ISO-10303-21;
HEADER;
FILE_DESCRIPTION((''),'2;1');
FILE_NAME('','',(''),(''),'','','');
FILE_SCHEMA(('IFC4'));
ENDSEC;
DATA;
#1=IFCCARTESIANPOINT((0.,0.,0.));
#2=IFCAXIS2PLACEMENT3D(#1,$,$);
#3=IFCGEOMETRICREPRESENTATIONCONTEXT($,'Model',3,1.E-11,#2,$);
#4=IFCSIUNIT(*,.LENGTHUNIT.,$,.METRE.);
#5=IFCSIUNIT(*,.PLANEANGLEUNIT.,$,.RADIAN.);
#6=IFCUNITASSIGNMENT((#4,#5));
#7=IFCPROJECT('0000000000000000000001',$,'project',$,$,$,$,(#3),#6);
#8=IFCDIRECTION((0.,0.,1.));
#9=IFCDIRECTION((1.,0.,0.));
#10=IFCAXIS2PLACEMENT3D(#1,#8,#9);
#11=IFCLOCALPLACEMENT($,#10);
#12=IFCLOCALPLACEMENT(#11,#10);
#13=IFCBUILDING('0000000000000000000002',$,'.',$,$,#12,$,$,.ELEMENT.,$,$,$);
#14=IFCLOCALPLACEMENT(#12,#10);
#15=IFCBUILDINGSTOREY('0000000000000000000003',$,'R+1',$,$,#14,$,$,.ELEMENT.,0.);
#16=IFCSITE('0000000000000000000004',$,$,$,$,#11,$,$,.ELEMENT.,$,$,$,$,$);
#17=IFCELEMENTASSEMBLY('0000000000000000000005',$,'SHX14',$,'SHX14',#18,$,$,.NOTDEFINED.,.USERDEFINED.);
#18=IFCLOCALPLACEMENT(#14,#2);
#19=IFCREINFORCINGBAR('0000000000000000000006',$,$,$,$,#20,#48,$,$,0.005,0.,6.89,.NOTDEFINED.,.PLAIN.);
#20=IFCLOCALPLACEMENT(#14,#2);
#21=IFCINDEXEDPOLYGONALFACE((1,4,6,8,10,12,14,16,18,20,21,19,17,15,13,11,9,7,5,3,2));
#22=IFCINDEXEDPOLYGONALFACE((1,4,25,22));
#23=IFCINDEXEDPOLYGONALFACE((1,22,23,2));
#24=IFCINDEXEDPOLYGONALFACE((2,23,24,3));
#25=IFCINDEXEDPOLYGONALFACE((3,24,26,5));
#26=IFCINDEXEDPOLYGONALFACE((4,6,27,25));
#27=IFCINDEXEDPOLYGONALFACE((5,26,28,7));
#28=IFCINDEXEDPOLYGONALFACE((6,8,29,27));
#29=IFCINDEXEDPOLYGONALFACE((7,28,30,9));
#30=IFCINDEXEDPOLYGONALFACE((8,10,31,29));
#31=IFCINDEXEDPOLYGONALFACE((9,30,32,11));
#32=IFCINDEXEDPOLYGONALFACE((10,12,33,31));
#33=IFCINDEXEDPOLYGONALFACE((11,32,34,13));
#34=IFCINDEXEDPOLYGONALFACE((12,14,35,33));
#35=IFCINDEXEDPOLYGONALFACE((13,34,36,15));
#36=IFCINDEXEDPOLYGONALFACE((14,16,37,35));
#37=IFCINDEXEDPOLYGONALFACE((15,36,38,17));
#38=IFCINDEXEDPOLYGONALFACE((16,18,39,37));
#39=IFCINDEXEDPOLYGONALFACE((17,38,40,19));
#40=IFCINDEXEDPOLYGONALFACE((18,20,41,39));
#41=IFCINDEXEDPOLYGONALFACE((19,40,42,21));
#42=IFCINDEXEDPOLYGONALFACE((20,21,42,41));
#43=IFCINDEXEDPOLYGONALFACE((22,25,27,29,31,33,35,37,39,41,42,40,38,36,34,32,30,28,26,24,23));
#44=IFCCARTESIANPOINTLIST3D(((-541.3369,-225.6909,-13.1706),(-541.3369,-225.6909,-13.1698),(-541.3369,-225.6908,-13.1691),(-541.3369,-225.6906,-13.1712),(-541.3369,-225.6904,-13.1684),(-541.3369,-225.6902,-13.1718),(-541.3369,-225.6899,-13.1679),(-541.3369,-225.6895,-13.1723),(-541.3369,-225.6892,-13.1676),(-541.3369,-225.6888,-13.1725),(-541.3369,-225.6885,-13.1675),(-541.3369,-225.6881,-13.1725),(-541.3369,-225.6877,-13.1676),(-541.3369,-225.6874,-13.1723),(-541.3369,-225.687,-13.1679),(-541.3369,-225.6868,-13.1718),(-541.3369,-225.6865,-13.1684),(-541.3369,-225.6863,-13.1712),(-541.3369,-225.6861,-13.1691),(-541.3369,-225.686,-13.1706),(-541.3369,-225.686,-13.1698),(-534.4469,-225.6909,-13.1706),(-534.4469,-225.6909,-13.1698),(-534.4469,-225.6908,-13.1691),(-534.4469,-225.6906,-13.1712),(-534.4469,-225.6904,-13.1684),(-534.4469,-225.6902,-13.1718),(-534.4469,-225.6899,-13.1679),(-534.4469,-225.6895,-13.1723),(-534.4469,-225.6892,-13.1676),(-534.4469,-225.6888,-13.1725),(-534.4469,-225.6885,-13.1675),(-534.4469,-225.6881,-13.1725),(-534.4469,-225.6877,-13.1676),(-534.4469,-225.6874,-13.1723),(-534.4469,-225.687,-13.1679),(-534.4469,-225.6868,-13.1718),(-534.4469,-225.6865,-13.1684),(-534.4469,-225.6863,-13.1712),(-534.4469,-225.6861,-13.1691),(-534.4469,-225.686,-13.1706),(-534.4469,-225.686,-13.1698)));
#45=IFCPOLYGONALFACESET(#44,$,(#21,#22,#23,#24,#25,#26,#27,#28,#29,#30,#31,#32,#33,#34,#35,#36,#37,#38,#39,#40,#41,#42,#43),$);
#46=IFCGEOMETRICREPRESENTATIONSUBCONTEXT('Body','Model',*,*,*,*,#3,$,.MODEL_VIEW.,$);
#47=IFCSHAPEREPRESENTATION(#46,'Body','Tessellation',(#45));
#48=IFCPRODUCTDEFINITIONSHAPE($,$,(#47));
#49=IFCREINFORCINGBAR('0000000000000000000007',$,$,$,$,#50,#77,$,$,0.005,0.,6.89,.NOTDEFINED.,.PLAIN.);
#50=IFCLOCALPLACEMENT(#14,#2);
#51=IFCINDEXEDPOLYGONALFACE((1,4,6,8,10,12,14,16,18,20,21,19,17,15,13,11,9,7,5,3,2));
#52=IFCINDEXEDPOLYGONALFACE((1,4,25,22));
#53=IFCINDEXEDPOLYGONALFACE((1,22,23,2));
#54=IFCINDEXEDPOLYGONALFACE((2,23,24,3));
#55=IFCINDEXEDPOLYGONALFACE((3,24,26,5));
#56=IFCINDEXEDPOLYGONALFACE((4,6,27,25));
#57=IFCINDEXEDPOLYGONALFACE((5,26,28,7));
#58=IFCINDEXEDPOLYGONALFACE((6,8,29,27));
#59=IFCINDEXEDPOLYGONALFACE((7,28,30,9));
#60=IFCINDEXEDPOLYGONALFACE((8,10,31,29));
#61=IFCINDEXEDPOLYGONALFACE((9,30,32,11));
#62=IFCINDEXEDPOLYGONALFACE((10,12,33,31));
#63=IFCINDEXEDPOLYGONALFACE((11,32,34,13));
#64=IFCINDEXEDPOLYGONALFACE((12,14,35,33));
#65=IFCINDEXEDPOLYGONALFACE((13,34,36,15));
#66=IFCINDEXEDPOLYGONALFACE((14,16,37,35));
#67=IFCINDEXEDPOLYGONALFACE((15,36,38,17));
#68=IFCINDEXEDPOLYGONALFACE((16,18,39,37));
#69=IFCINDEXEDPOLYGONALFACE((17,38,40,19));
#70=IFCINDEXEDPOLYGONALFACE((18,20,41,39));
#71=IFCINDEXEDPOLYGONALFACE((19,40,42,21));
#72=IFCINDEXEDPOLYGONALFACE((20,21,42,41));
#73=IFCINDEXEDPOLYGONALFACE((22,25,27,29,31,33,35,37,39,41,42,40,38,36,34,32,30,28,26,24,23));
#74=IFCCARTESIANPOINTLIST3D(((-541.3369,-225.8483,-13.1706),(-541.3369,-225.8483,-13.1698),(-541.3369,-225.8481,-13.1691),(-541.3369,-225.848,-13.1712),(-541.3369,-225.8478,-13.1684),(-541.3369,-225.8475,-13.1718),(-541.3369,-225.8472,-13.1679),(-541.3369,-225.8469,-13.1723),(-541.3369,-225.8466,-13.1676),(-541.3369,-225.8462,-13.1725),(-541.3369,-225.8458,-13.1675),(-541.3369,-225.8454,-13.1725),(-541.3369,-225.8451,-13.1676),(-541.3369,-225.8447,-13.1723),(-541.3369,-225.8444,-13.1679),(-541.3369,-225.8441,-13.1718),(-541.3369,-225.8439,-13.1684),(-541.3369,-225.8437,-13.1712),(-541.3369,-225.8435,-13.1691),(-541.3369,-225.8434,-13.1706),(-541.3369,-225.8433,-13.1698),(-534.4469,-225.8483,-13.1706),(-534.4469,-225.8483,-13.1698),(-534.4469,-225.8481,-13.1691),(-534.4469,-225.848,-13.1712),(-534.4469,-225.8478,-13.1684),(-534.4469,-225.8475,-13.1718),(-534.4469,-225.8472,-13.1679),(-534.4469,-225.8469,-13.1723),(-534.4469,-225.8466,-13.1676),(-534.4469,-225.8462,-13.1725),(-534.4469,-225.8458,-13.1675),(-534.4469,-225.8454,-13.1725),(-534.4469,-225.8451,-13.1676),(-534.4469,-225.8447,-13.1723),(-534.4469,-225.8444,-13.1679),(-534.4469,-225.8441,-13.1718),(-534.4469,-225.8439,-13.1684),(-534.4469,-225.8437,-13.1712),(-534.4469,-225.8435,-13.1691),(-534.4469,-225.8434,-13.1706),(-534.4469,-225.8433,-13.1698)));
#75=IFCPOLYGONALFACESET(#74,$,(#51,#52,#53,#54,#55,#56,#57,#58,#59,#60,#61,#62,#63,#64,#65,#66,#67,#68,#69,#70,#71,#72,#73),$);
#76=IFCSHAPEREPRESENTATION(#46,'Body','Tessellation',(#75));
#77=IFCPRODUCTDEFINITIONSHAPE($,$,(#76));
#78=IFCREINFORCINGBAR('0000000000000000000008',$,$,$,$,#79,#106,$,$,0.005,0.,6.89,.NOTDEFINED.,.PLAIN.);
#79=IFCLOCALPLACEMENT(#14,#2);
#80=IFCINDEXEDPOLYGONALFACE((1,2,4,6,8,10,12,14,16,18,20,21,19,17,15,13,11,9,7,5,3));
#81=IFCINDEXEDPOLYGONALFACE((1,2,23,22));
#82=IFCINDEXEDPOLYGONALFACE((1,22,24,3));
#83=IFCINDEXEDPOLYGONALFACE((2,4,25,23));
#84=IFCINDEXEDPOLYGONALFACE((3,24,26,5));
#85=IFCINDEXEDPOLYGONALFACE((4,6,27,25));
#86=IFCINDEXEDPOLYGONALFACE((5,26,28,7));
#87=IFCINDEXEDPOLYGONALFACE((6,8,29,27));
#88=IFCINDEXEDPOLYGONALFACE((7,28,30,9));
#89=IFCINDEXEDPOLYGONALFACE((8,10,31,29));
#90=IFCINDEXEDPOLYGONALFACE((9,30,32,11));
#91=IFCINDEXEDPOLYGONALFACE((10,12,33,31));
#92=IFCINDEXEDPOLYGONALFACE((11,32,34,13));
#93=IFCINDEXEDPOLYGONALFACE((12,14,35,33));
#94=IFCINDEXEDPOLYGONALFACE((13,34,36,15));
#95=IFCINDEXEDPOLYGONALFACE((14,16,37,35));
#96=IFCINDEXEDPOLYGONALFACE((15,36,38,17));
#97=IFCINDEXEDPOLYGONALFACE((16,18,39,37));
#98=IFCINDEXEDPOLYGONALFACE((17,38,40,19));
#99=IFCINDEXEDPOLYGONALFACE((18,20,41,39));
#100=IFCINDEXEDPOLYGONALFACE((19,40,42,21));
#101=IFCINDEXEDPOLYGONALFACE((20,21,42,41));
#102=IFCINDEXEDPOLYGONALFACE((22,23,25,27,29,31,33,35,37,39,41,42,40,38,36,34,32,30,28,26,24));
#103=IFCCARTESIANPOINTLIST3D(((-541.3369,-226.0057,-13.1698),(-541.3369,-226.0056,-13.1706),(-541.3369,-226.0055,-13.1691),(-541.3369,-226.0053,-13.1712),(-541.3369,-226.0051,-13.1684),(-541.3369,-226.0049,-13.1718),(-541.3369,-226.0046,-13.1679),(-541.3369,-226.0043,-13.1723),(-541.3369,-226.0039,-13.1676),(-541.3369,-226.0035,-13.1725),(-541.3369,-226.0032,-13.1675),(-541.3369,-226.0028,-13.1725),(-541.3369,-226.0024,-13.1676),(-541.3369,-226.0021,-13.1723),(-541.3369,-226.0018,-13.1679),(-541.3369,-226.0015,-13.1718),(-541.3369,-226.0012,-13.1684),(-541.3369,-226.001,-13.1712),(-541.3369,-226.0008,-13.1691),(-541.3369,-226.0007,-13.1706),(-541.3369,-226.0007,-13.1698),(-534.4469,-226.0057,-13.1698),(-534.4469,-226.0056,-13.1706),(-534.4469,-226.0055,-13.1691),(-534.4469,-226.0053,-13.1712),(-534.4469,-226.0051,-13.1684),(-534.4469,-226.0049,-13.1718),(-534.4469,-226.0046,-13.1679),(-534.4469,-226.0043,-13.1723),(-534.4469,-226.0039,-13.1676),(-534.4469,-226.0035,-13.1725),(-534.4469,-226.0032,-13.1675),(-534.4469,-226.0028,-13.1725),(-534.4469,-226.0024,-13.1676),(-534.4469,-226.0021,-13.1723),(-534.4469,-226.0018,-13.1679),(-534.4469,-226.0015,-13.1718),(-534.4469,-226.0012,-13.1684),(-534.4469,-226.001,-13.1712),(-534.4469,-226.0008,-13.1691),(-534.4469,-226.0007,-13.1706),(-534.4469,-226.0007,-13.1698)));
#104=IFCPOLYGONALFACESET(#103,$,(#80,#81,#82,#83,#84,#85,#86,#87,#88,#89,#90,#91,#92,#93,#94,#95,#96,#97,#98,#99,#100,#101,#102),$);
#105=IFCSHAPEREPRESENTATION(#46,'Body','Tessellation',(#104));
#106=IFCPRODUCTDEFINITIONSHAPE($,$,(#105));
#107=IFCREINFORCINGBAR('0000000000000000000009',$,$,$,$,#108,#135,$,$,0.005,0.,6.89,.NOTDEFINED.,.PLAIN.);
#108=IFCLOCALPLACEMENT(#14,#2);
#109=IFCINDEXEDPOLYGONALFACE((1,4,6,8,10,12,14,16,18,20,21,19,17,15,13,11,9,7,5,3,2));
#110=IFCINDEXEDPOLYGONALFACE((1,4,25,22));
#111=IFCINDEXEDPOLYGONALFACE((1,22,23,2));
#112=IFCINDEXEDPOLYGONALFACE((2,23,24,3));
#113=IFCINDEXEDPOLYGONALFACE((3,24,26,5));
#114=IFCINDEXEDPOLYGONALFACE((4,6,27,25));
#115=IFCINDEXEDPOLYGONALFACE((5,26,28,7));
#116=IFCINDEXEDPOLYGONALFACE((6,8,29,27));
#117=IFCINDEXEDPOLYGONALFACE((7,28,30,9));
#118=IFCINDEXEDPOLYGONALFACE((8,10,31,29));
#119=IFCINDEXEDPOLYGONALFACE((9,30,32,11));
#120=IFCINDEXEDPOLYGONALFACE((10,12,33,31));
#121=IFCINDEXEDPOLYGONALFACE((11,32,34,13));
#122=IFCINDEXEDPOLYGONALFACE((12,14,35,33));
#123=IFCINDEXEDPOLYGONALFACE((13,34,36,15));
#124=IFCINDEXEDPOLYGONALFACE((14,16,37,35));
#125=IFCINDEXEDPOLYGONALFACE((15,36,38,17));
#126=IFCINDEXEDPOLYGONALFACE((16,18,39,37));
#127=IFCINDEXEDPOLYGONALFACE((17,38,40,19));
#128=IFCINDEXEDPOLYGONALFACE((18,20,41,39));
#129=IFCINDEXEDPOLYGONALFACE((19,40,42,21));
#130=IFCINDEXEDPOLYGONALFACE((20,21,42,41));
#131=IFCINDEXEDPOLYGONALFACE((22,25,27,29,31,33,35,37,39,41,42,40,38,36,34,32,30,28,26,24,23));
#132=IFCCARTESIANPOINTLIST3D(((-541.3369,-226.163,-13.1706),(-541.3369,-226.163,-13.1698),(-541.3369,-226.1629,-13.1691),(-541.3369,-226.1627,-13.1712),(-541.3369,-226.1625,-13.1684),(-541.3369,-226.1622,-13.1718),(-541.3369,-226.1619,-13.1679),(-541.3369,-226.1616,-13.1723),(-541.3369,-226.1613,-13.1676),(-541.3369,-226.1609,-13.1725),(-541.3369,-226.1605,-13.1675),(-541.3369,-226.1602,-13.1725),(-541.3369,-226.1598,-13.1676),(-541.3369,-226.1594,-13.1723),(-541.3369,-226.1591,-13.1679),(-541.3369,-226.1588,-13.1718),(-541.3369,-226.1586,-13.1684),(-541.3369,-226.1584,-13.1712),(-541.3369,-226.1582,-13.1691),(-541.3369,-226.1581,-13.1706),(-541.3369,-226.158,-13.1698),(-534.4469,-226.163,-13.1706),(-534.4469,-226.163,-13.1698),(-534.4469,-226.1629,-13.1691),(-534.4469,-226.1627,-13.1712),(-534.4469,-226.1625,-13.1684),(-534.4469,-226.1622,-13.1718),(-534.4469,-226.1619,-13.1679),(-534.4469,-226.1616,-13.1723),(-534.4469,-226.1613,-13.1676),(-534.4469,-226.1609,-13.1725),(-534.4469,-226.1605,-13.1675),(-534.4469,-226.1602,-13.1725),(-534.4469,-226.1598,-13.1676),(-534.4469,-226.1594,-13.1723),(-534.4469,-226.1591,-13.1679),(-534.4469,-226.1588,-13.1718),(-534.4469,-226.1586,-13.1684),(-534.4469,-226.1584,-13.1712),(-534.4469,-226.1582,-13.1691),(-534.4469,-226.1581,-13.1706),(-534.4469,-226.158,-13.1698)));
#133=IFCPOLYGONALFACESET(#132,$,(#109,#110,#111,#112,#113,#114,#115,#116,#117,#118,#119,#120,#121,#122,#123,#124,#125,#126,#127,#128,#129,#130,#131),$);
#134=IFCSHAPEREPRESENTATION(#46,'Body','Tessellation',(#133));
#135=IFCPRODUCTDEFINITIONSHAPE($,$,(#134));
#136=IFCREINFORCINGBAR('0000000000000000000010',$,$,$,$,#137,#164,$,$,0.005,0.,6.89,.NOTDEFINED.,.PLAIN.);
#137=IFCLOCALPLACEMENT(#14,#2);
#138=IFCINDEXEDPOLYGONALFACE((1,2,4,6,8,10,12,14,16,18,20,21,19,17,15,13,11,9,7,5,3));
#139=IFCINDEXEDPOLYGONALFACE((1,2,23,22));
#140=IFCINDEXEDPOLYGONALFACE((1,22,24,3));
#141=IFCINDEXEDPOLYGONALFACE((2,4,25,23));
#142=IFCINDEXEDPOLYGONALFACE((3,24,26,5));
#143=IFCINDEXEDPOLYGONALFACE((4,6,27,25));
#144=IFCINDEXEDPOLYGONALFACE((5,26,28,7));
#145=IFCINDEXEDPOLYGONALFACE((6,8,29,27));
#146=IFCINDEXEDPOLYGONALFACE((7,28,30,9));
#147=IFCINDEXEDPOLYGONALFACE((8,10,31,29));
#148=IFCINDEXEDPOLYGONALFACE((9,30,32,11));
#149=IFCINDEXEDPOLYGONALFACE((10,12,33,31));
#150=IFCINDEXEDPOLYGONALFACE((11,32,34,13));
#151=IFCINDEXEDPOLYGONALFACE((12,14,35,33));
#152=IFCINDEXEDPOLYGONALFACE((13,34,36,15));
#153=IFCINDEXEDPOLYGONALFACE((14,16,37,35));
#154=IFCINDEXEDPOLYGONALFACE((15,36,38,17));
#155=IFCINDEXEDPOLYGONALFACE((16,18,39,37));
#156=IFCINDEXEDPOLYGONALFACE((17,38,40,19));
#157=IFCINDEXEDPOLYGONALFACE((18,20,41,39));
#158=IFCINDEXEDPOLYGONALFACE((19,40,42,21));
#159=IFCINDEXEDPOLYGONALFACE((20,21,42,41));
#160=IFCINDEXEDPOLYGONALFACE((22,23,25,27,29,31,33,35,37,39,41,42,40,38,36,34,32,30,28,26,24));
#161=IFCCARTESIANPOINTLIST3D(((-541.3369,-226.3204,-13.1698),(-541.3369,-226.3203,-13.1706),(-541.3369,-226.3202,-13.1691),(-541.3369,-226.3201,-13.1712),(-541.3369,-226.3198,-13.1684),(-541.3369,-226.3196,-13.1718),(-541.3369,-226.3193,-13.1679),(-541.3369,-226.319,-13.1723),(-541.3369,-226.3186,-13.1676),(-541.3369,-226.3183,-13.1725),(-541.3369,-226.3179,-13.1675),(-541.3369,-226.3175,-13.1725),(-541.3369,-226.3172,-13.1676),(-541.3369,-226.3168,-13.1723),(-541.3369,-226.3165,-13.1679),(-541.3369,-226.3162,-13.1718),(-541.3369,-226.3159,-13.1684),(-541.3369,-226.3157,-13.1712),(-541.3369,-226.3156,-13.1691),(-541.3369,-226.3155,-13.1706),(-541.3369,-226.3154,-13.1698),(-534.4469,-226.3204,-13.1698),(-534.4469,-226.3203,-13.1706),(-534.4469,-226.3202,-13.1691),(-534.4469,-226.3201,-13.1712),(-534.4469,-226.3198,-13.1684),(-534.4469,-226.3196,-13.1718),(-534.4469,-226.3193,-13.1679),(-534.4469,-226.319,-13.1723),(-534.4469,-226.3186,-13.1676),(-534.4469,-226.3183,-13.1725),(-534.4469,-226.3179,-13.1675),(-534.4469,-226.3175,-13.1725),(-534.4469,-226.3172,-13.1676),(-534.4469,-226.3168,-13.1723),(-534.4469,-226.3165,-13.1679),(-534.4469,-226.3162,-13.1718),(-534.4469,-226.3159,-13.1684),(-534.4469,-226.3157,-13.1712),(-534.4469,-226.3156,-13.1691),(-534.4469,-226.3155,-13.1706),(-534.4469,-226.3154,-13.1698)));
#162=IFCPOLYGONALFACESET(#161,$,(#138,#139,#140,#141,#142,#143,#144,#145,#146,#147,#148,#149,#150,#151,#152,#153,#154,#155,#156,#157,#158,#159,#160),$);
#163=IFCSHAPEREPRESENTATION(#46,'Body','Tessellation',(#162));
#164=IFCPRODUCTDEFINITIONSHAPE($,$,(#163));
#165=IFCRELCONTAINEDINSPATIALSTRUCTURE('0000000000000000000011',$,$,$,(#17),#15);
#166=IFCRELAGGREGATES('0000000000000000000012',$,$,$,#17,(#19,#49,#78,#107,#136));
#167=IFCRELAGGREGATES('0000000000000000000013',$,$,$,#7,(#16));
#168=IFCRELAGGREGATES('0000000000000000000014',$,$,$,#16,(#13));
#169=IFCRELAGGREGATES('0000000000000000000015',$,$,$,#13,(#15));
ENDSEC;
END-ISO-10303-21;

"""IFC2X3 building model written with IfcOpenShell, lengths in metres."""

from ifc_helpers import new_model, entity, si_unit, origin, origin_with_axes, place, context, subcontext, project, spatial, shape, element, aggregate, save


model = new_model("IFC2X3")

# Units and contexts
model_context = context("Model", 3, precision=1e-11, world=origin())
body_context = subcontext(model_context, "Body", "Model", "MODEL_VIEW")
ifc_project = project(units=[si_unit("LENGTHUNIT", "METRE"), si_unit("PLANEANGLEUNIT", "RADIAN")], contexts=[model_context])

# Site, building, storey
site_placement = place(None, origin_with_axes())
site = spatial("IfcSite", under=ifc_project, at=site_placement, CompositionType="ELEMENT")
building_placement = place(site_placement, origin_with_axes())
building = spatial("IfcBuilding", under=site, at=building_placement, Name=".", CompositionType="ELEMENT")
storey_placement = place(building_placement, origin_with_axes())
storey = spatial("IfcBuildingStorey", under=building, at=storey_placement, Name="R+1", CompositionType="ELEMENT", Elevation=0.0)

# Element assembly, reinforcing bars
assembly_1_placement = place(storey_placement, origin_with_axes())
assembly_1 = element("IfcElementAssembly", 1, at=assembly_1_placement, inside=storey, Name="SHX14", ObjectType="SHX14", AssemblyPlace="NOTDEFINED", PredefinedType="USERDEFINED")
reinforcing_bar_1_placement = place(assembly_1_placement, origin_with_axes())
reinforcing_bar_1 = element("IfcReinforcingBar", 2, at=reinforcing_bar_1_placement, BarLength=6.89, BarRole="NOTDEFINED", BarSurface="PLAIN", CrossSectionArea=0.0, NominalDiameter=0.005, shapes=[
    shape(body_context, "Body", "AdvancedSweptSolid", [entity("IfcSweptDiskSolid", entity("IfcPolyline", [entity("IfcCartesianPoint", [534.4469, 225.6885, 13.17]), entity("IfcCartesianPoint", [541.3369, 225.6885, 13.17])]), 0.0025, None, 0.0, 6.89)]),
    shape(body_context, "Body", "AdvancedSweptSolid", [entity("IfcSweptDiskSolid", entity("IfcPolyline", [entity("IfcCartesianPoint", [534.4469, 225.6885, 13.17]), entity("IfcCartesianPoint", [541.3369, 225.6885, 13.17])]), 0.0025, None, 0.0, 6.89)]),
])
reinforcing_bar_2_placement = place(assembly_1_placement, origin_with_axes())
reinforcing_bar_2 = element("IfcReinforcingBar", 3, at=reinforcing_bar_2_placement, BarLength=6.89, BarRole="NOTDEFINED", BarSurface="PLAIN", CrossSectionArea=0.0, NominalDiameter=0.005, shapes=[
    shape(body_context, "Body", "AdvancedSweptSolid", [entity("IfcSweptDiskSolid", entity("IfcPolyline", [entity("IfcCartesianPoint", [534.4469, 225.8458, 13.17]), entity("IfcCartesianPoint", [541.3369, 225.8458, 13.17])]), 0.0025, None, 0.0, 6.89)]),
    shape(body_context, "Body", "AdvancedSweptSolid", [entity("IfcSweptDiskSolid", entity("IfcPolyline", [entity("IfcCartesianPoint", [534.4469, 225.8458, 13.17]), entity("IfcCartesianPoint", [541.3369, 225.8458, 13.17])]), 0.0025, None, 0.0, 6.89)]),
])
reinforcing_bar_3_placement = place(assembly_1_placement, origin_with_axes())
reinforcing_bar_3 = element("IfcReinforcingBar", 4, at=reinforcing_bar_3_placement, BarLength=6.89, BarRole="NOTDEFINED", BarSurface="PLAIN", CrossSectionArea=0.0, NominalDiameter=0.005, shapes=[
    shape(body_context, "Body", "AdvancedSweptSolid", [entity("IfcSweptDiskSolid", entity("IfcPolyline", [entity("IfcCartesianPoint", [534.4469, 226.0032, 13.17]), entity("IfcCartesianPoint", [541.3369, 226.0032, 13.17])]), 0.0025, None, 0.0, 6.89)]),
    shape(body_context, "Body", "AdvancedSweptSolid", [entity("IfcSweptDiskSolid", entity("IfcPolyline", [entity("IfcCartesianPoint", [534.4469, 226.0032, 13.17]), entity("IfcCartesianPoint", [541.3369, 226.0032, 13.17])]), 0.0025, None, 0.0, 6.89)]),
])
reinforcing_bar_4_placement = place(assembly_1_placement, origin_with_axes())
reinforcing_bar_4 = element("IfcReinforcingBar", 5, at=reinforcing_bar_4_placement, BarLength=6.89, BarRole="NOTDEFINED", BarSurface="PLAIN", CrossSectionArea=0.0, NominalDiameter=0.005, shapes=[
    shape(body_context, "Body", "AdvancedSweptSolid", [entity("IfcSweptDiskSolid", entity("IfcPolyline", [entity("IfcCartesianPoint", [534.4469, 226.1605, 13.17]), entity("IfcCartesianPoint", [541.3369, 226.1605, 13.17])]), 0.0025, None, 0.0, 6.89)]),
    shape(body_context, "Body", "AdvancedSweptSolid", [entity("IfcSweptDiskSolid", entity("IfcPolyline", [entity("IfcCartesianPoint", [534.4469, 226.1605, 13.17]), entity("IfcCartesianPoint", [541.3369, 226.1605, 13.17])]), 0.0025, None, 0.0, 6.89)]),
])
reinforcing_bar_5_placement = place(assembly_1_placement, origin_with_axes())
reinforcing_bar_5 = element("IfcReinforcingBar", 6, at=reinforcing_bar_5_placement, BarLength=6.89, BarRole="NOTDEFINED", BarSurface="PLAIN", CrossSectionArea=0.0, NominalDiameter=0.005, shapes=[
    shape(body_context, "Body", "AdvancedSweptSolid", [entity("IfcSweptDiskSolid", entity("IfcPolyline", [entity("IfcCartesianPoint", [534.4469, 226.3179, 13.17]), entity("IfcCartesianPoint", [541.3369, 226.3179, 13.17])]), 0.0025, None, 0.0, 6.89)]),
    shape(body_context, "Body", "AdvancedSweptSolid", [entity("IfcSweptDiskSolid", entity("IfcPolyline", [entity("IfcCartesianPoint", [534.4469, 226.3179, 13.17]), entity("IfcCartesianPoint", [541.3369, 226.3179, 13.17])]), 0.0025, None, 0.0, 6.89)]),
])
aggregate(assembly_1, [reinforcing_bar_1, reinforcing_bar_2, reinforcing_bar_3, reinforcing_bar_4, reinforcing_bar_5])

save(model, "model.ifc")
